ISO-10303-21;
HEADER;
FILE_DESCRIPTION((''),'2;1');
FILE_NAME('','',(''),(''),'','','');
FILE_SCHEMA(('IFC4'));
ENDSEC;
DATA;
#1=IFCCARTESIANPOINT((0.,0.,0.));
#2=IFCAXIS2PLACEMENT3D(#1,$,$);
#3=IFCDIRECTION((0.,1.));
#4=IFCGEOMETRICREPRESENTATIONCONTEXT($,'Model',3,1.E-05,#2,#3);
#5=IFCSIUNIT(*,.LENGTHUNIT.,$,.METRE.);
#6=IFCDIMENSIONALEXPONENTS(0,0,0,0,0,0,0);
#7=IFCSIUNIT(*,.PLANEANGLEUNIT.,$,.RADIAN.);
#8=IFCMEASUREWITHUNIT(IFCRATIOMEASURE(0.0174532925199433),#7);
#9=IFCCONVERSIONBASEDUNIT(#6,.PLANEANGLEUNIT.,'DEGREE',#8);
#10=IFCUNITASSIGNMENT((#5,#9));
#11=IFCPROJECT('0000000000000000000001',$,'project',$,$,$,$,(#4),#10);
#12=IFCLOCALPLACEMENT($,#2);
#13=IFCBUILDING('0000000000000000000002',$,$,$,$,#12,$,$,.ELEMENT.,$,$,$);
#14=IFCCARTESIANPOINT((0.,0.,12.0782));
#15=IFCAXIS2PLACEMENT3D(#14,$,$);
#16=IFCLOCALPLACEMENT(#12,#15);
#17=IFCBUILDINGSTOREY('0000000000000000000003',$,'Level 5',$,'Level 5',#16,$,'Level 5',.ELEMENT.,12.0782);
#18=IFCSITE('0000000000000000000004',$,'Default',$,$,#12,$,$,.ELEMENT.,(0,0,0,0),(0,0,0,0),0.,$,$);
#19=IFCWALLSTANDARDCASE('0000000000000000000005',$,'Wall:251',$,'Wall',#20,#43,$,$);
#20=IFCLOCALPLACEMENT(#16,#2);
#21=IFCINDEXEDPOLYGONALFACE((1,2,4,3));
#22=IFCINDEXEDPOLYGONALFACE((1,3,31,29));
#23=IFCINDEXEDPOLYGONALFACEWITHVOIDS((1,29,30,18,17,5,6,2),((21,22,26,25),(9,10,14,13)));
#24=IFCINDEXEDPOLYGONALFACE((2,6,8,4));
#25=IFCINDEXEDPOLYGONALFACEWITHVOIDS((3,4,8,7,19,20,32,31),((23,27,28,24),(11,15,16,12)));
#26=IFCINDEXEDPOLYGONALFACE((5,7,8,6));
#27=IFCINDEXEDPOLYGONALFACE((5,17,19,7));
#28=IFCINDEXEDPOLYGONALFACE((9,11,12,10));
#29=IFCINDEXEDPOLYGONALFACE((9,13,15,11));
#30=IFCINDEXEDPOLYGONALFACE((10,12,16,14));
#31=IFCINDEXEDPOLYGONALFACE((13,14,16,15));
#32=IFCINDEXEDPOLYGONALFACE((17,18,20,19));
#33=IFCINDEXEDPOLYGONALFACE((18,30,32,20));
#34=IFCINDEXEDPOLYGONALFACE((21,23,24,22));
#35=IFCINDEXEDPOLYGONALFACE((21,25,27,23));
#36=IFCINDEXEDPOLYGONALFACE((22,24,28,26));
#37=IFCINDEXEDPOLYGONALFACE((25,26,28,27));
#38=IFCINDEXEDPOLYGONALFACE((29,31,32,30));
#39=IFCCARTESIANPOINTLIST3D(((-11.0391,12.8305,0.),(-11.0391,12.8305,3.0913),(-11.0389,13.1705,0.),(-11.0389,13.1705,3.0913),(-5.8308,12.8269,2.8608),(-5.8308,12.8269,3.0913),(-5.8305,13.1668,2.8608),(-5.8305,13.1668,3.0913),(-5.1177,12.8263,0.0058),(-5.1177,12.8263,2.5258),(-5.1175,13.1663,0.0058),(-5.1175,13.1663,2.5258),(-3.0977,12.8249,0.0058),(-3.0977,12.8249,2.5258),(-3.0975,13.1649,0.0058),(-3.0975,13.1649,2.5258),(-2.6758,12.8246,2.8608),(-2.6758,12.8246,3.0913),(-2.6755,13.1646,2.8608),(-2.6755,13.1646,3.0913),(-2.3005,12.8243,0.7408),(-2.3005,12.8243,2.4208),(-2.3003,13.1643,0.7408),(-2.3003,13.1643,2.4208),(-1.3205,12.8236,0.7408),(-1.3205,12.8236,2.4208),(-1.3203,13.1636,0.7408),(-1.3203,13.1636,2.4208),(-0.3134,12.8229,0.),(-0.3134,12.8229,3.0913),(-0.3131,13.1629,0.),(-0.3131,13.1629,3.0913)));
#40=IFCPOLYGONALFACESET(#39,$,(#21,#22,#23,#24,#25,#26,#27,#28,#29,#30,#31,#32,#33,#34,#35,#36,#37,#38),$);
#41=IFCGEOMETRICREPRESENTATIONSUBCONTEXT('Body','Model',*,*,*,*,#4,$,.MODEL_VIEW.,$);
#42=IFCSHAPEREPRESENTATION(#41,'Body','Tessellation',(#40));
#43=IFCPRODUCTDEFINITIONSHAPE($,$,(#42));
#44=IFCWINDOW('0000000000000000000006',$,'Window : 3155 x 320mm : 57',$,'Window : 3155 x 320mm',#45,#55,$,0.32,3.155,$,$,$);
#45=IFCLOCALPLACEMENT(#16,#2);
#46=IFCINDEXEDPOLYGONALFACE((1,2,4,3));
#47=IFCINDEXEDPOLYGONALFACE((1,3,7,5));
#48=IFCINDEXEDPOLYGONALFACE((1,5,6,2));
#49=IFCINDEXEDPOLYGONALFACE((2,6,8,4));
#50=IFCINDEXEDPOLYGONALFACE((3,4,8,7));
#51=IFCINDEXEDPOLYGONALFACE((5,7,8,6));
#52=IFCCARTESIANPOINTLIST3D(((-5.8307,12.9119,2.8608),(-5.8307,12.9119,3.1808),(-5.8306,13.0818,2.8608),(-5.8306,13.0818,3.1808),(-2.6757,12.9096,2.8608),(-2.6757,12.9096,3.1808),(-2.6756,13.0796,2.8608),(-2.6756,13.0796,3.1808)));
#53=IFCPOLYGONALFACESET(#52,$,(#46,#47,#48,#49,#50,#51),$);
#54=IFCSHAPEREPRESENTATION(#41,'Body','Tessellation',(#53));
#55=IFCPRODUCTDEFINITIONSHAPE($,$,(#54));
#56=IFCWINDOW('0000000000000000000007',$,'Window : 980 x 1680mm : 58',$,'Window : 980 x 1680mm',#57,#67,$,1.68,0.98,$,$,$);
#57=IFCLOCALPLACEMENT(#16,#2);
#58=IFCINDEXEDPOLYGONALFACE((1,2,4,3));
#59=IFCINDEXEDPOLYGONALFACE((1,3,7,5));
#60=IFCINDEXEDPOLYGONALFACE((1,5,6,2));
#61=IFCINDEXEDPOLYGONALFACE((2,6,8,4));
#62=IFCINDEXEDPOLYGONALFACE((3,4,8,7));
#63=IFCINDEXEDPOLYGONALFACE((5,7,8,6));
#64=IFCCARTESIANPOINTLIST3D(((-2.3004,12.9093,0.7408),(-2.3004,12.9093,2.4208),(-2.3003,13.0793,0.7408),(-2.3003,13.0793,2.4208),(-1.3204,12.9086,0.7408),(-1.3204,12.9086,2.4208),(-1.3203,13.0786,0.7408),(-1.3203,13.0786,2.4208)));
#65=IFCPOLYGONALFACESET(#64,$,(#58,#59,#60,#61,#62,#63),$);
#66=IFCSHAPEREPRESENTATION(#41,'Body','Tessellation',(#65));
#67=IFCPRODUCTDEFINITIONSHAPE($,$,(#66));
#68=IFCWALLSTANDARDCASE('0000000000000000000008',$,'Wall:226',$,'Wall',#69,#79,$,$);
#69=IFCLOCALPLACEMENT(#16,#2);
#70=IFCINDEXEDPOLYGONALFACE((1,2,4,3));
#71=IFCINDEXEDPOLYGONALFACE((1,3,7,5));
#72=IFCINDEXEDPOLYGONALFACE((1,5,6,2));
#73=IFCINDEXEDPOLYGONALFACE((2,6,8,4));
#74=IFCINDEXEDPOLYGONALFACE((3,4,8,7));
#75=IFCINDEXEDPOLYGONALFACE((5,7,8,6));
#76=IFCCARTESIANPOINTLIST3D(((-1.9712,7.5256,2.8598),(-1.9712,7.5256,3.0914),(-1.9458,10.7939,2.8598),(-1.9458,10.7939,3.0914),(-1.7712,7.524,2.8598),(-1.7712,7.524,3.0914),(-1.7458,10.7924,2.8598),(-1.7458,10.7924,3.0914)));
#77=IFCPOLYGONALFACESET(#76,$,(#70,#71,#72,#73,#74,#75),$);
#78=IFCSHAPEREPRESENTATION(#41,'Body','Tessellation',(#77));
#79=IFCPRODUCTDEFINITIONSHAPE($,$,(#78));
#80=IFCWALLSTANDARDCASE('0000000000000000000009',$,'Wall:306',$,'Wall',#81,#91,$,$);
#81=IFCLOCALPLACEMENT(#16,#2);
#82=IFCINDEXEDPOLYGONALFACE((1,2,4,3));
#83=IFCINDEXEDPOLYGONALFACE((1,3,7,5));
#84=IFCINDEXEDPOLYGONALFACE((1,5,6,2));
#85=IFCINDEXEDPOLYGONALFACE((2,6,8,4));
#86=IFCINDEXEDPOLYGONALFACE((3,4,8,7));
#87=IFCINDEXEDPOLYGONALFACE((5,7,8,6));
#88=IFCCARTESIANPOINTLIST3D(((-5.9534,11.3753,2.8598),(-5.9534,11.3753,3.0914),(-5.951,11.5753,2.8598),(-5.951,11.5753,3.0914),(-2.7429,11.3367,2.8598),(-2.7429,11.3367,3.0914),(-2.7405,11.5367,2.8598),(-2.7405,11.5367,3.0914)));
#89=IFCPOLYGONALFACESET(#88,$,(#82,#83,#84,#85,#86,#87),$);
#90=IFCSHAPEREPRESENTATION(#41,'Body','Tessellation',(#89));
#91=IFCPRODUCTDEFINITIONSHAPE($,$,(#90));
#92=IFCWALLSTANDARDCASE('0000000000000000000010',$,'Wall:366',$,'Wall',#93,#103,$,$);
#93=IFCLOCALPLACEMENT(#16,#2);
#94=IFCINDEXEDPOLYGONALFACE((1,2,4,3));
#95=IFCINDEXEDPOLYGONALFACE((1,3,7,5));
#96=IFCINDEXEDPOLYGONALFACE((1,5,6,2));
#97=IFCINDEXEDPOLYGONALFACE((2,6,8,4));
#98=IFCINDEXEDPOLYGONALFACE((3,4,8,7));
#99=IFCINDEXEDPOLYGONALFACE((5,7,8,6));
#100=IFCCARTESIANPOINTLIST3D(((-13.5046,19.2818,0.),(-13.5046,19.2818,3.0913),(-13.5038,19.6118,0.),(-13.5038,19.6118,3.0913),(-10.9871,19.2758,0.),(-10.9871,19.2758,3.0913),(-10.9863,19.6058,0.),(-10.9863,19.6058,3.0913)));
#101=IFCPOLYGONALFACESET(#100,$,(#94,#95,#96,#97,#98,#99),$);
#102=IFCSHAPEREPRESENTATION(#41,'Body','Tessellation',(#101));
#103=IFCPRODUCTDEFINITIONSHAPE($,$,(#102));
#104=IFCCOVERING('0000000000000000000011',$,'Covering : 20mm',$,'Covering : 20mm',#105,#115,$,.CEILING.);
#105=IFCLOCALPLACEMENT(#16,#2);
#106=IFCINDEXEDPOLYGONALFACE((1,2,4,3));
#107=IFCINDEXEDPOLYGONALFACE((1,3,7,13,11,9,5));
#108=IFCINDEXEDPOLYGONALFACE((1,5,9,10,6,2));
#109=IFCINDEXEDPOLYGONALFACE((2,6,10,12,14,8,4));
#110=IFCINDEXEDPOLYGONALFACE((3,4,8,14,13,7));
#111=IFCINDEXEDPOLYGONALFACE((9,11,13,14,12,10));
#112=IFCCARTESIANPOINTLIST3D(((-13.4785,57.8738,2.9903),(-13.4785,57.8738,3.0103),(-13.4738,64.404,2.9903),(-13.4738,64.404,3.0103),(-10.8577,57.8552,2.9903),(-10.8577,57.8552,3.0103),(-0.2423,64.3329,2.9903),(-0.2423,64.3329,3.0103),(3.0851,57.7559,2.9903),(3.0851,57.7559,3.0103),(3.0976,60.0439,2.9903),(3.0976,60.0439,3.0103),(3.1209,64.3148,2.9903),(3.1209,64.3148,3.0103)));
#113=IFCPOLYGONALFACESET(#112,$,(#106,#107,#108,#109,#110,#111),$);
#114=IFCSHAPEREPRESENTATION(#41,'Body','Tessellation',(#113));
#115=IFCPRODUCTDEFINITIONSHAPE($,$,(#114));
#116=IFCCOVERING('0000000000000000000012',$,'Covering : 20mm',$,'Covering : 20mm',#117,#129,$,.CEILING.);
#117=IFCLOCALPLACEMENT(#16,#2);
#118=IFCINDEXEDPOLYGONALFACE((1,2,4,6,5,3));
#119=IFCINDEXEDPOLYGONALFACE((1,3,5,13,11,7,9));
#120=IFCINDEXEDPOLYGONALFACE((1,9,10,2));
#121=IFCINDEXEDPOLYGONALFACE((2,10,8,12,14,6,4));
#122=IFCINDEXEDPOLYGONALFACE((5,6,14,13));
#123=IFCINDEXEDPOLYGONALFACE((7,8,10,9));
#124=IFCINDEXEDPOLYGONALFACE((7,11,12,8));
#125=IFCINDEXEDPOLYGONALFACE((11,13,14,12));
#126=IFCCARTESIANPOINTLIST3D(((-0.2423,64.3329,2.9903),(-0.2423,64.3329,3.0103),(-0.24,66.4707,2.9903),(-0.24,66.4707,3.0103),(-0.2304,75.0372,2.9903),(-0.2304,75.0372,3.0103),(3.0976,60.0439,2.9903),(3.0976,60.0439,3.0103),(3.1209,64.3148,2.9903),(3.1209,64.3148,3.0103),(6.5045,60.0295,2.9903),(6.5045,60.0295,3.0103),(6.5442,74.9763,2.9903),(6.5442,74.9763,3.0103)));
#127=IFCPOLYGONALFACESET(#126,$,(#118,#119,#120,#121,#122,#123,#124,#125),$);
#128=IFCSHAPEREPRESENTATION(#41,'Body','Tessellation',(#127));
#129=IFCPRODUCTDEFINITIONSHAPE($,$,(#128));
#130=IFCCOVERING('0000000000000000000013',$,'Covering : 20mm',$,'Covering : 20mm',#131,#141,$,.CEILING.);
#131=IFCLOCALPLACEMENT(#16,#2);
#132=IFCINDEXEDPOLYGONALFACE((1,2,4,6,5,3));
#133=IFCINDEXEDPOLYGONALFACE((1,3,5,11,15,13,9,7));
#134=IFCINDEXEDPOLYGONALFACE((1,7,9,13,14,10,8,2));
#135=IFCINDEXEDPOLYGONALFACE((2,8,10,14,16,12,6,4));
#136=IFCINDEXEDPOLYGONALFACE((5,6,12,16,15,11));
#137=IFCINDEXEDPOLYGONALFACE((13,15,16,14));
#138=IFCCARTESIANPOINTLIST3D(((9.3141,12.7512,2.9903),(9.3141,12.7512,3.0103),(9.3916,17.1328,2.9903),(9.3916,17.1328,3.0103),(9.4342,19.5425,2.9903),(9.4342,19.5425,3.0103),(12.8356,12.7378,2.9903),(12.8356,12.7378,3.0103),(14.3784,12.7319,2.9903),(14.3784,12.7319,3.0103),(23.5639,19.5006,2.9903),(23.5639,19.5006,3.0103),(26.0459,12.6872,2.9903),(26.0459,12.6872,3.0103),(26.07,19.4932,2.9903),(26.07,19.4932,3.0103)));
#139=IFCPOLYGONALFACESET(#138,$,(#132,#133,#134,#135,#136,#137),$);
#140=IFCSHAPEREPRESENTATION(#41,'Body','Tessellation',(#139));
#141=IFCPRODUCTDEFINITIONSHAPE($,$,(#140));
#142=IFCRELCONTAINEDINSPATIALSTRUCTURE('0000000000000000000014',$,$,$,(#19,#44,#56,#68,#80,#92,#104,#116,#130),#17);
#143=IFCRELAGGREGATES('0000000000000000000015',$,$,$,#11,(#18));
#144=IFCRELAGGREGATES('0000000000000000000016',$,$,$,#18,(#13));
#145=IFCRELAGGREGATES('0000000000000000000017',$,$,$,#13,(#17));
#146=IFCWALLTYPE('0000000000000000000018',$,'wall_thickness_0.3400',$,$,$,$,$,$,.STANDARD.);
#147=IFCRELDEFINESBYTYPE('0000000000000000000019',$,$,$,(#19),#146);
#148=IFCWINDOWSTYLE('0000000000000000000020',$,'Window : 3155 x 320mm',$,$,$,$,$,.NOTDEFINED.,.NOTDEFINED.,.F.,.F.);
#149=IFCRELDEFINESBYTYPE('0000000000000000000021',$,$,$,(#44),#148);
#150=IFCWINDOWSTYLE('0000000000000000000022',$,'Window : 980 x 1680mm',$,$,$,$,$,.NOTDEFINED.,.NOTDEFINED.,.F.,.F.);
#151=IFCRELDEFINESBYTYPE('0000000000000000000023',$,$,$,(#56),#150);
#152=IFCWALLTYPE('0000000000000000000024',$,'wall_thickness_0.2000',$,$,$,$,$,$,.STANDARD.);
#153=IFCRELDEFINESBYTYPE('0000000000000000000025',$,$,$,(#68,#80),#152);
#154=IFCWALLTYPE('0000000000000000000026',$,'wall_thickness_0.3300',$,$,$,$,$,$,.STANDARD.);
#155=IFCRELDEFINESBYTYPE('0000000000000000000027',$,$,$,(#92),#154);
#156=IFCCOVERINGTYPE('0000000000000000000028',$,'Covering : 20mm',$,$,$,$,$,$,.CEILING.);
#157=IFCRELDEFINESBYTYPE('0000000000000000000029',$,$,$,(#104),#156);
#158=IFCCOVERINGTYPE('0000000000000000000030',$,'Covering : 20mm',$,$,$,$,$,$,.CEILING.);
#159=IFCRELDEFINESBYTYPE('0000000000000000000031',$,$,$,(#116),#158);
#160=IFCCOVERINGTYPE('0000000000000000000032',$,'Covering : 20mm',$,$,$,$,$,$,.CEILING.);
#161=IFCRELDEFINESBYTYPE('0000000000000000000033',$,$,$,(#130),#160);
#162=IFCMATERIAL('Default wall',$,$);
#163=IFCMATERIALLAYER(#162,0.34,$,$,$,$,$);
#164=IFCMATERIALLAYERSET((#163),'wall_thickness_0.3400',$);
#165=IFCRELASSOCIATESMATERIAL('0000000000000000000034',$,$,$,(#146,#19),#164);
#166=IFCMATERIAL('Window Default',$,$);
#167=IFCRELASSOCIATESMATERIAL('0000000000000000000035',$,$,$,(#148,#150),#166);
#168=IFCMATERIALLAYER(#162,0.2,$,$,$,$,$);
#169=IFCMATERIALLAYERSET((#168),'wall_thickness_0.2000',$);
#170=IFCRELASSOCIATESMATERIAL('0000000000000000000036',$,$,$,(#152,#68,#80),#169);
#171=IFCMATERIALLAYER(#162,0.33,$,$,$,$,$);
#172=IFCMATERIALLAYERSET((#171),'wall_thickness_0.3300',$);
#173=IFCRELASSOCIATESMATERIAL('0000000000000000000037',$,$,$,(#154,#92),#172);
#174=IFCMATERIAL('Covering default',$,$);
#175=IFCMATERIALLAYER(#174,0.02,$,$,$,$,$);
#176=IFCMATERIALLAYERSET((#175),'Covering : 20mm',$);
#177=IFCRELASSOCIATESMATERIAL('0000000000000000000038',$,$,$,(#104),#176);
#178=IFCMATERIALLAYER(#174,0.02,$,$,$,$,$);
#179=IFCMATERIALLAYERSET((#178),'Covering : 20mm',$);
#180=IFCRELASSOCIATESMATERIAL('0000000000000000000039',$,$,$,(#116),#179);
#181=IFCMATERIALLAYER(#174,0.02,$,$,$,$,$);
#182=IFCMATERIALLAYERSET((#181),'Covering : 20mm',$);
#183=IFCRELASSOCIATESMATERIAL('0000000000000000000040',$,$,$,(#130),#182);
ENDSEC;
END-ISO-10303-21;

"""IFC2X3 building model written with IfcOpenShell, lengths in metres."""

from ifc_helpers import new_model, entity, si_unit, converted_unit, direction, frame, frame_2d, origin, origin_with_axes, origin_2d_with_axis, place, context, subcontext, project, spatial, polyline, rectangle, outline, extrude, clip, halfspace, source, transform, mapped, material, layer, layer_set, layer_usage, type_object, type_shapes, element, fill, save


model = new_model("IFC2X3")

# Units and contexts
model_context = context("Model", 3, precision=1e-05, world=origin(), true_north=direction((0.0, 1.0)))
body_context = subcontext(model_context, "Body", "Model", "MODEL_VIEW")
ifc_project = project(units=[si_unit("LENGTHUNIT", "METRE"), converted_unit("PLANEANGLEUNIT", "DEGREE", entity("IfcRatioMeasure", 0.0174532925199433), si_unit("PLANEANGLEUNIT", "RADIAN"), dimensions=[0, 0, 0, 0, 0, 0, 0])], contexts=[model_context])

# Site, building, storey
placement_1 = place(None, origin())
site = spatial("IfcSite", under=ifc_project, at=placement_1, Name="Default", CompositionType="ELEMENT", RefLatitude=(0, 0, 0, 0), RefLongitude=(0, 0, 0, 0), RefElevation=0.0)
building = spatial("IfcBuilding", under=site, at=placement_1, CompositionType="ELEMENT")
storey_placement = place(placement_1, frame((0.0, 0.0, 12.0782)))
storey = spatial("IfcBuildingStorey", under=building, at=storey_placement, Name="Level 5", ObjectType="Level 5", LongName="Level 5", CompositionType="ELEMENT", Elevation=12.0782)

# Shared definitions
ifc_material_1 = material(Name="Default wall")
ifc_material_2 = material(Name="Window Default")

# Wall, openings, windows
ifc_layer_1 = layer(ifc_material_1, 0.34)
ifc_layer_set_1 = layer_set([ifc_layer_1], Name="wall_thickness_0.3400")
ifc_layer_usage_1 = layer_usage(ifc_layer_set_1, "AXIS2", "POSITIVE", -0.17)
wall_type_1 = type_object("IfcWallType", Name="wall_thickness_0.3400", PredefinedType="STANDARD", material=ifc_layer_set_1)
wall_1_placement = place(storey_placement, frame((-11.039, 13.0005, 0.0), z_axis=(0.0, 0.0, 1.0), x_axis=(1.0, -0.00071, 0.0)))
wall_1 = element("IfcWallStandardCase", 1, at=wall_1_placement, inside=storey, type_object=wall_type_1, material=ifc_layer_usage_1, Name="Wall:251", ObjectType="Wall", context=body_context, shape_type="Clipping", body=[
    clip(extrude(outline(polyline([(10.7257, -0.17), (10.7257, 0.17), (0.0, 0.17), (0.0, -0.17), (10.7257, -0.17)])), origin(), (0.0, 0.0, 1.0), 3.0913), halfspace(frame((-0.999, 6.5926, 8.9869), z_axis=(-0.004015, -0.38912, 0.921178), x_axis=(0.999958, -0.009108, 0.000511)), False)),
])
opening_1_placement = place(wall_1_placement, frame((5.9214, -0.17, 0.0058)))
element("IfcOpeningElement", 2, at=opening_1_placement, cuts=wall_1, ObjectType="Opening", context=body_context, shape_type="SweptSolid", body=[
    extrude(rectangle(XDim=2.02, YDim=2.52, at=frame_2d((1.26, 1.01), x_axis=(0.0, 1.0))), frame((0.0, 0.0, 0.0), z_axis=(0.0, 1.0, 0.0), x_axis=(0.0, 0.0, 1.0)), (0.0, 0.0, 1.0), 0.34),
])
opening_2_placement = place(wall_1_placement, frame((5.2083, -0.17, 2.8608)))
opening_2 = element("IfcOpeningElement", 3, at=opening_2_placement, cuts=wall_1, ObjectType="Opening", context=body_context, shape_type="SweptSolid", body=[
    extrude(rectangle(XDim=3.155, YDim=0.32, at=frame_2d((0.16, 1.5775), x_axis=(0.0, 1.0))), frame((0.0, 0.0, 0.0), z_axis=(0.0, 1.0, 0.0), x_axis=(0.0, 0.0, 1.0)), (0.0, 0.0, 1.0), 0.34),
])
opening_3_placement = place(wall_1_placement, frame((8.7386, -0.17, 0.7408)))
opening_3 = element("IfcOpeningElement", 4, at=opening_3_placement, cuts=wall_1, ObjectType="Opening", context=body_context, shape_type="SweptSolid", body=[
    extrude(rectangle(XDim=0.98, YDim=1.68, at=frame_2d((0.84, 0.49), x_axis=(0.0, 1.0))), frame((0.0, 0.0, 0.0), z_axis=(0.0, 1.0, 0.0), x_axis=(0.0, 0.0, 1.0)), (0.0, 0.0, 1.0), 0.34),
])
window_style_1 = type_object("IfcWindowStyle", Name="Window : 3155 x 320mm", ConstructionType="NOTDEFINED", OperationType="NOTDEFINED", ParameterTakesPrecedence=False, Sizeable=False, material=ifc_material_2)
shared_shape_1 = source(origin(), body_context, "Body", "SweptSolid", [
    extrude(rectangle(XDim=0.17, YDim=3.155, at=origin_2d_with_axis()), frame((1.5775, 0.17, 0.0), z_axis=(0.0, 0.0, 1.0), x_axis=(0.0, 1.0, 0.0)), (0.0, 0.0, 1.0), 0.32),
])
type_shapes(window_style_1, [shared_shape_1])
window_1_placement = place(opening_2_placement, origin())
window_1 = element("IfcWindow", 5, at=window_1_placement, inside=storey, type_object=window_style_1, Name="Window : 3155 x 320mm : 57", ObjectType="Window : 3155 x 320mm", OverallHeight=0.32, OverallWidth=3.155, context=body_context, shape_type="MappedRepresentation", body=[
    mapped(shared_shape_1, transform((0.0, 0.0, 0.0), scale=1.0)),
])
fill(opening_2, window_1)
window_style_2 = type_object("IfcWindowStyle", Name="Window : 980 x 1680mm", ConstructionType="NOTDEFINED", OperationType="NOTDEFINED", ParameterTakesPrecedence=False, Sizeable=False, material=ifc_material_2)
shared_shape_2 = source(origin(), body_context, "Body", "SweptSolid", [
    extrude(rectangle(XDim=0.17, YDim=0.98, at=origin_2d_with_axis()), frame((0.49, 0.17, 0.0), z_axis=(0.0, 0.0, 1.0), x_axis=(0.0, 1.0, 0.0)), (0.0, 0.0, 1.0), 1.68),
])
type_shapes(window_style_2, [shared_shape_2])
window_2_placement = place(opening_3_placement, origin())
window_2 = element("IfcWindow", 6, at=window_2_placement, inside=storey, type_object=window_style_2, Name="Window : 980 x 1680mm : 58", ObjectType="Window : 980 x 1680mm", OverallHeight=1.68, OverallWidth=0.98, context=body_context, shape_type="MappedRepresentation", body=[
    mapped(shared_shape_2, transform((0.0, 0.0, 0.0), scale=1.0)),
])
fill(opening_3, window_2)

# Walls
ifc_layer_2 = layer(ifc_material_1, 0.2)
ifc_layer_set_2 = layer_set([ifc_layer_2], Name="wall_thickness_0.2000")
ifc_layer_usage_2 = layer_usage(ifc_layer_set_2, "AXIS2", "POSITIVE", -0.1)
wall_type_2 = type_object("IfcWallType", Name="wall_thickness_0.2000", PredefinedType="STANDARD", material=ifc_layer_set_2)
placement_2 = place(placement_1, frame((0.0, 0.0, 14.938)))
wall_2_placement = place(placement_2, frame((-1.8458, 10.7932, 0.0), z_axis=(0.0, 0.0, 1.0), x_axis=(-0.007747, -0.99997, 0.0)))
element("IfcWallStandardCase", 7, at=wall_2_placement, inside=storey, type_object=wall_type_2, material=ifc_layer_usage_2, Name="Wall:226", ObjectType="Wall", context=body_context, shape_type="SweptSolid", body=[
    extrude(outline(polyline([(3.2685, -0.1), (3.2685, 0.1), (0.0, 0.1), (0.0, -0.1), (3.2685, -0.1)])), origin(), (0.0, 0.0, 1.0), 0.2316),
])
placement_3 = place(placement_1, frame((0.0, 0.0, 14.938)))
wall_3_placement = place(placement_3, frame((-5.9522, 11.4753, 0.0), z_axis=(0.0, 0.0, 1.0), x_axis=(0.999928, -0.012018, 0.0)))
element("IfcWallStandardCase", 8, at=wall_3_placement, inside=storey, type_object=wall_type_2, material=ifc_layer_usage_2, Name="Wall:306", ObjectType="Wall", context=body_context, shape_type="SweptSolid", body=[
    extrude(outline(polyline([(3.2108, -0.1), (3.2108, 0.1), (0.0, 0.1), (0.0, -0.1), (3.2108, -0.1)])), origin(), (0.0, 0.0, 1.0), 0.2316),
])
ifc_layer_3 = layer(ifc_material_1, 0.33)
ifc_layer_set_3 = layer_set([ifc_layer_3], Name="wall_thickness_0.3300")
ifc_layer_usage_3 = layer_usage(ifc_layer_set_3, "AXIS2", "POSITIVE", -0.165)
wall_type_3 = type_object("IfcWallType", Name="wall_thickness_0.3300", PredefinedType="STANDARD", material=ifc_layer_set_3)
wall_4_placement = place(storey_placement, frame((-13.5042, 19.4468, 0.0), z_axis=(0.0, 0.0, 1.0), x_axis=(0.999997, -0.002393, 0.0)))
element("IfcWallStandardCase", 9, at=wall_4_placement, inside=storey, type_object=wall_type_3, material=ifc_layer_usage_3, Name="Wall:366", ObjectType="Wall", context=body_context, shape_type="SweptSolid", body=[
    extrude(outline(polyline([(2.5175, -0.165), (2.5175, 0.165), (0.0, 0.165), (0.0, -0.165), (2.5175, -0.165)])), origin(), (0.0, 0.0, 1.0), 3.0913),
])

# Coverings
ifc_material_3 = material(Name="Covering default")
ifc_layer_4 = layer(ifc_material_3, 0.02)
ifc_layer_set_4 = layer_set([ifc_layer_4], Name="Covering : 20mm")
ifc_layer_usage_4 = layer_usage(ifc_layer_set_4, "AXIS3", "POSITIVE", 0.0)
covering_type_1 = type_object("IfcCoveringType", Name="Covering : 20mm", PredefinedType="CEILING")
covering_1_placement = place(placement_1, frame((0.0, 0.0, 15.0685)))
element("IfcCovering", 10, at=covering_1_placement, inside=storey, type_object=covering_type_1, material=ifc_layer_usage_4, Name="Covering : 20mm", ObjectType="Covering : 20mm", PredefinedType="CEILING", context=body_context, shape_type="SweptSolid", body=[
    extrude(outline(polyline([(3.1209, 64.3148), (-0.2423, 64.3329), (-13.4738, 64.404), (-13.4785, 57.8738), (-10.8577, 57.8552), (3.0851, 57.7559), (3.0976, 60.0439), (3.1209, 64.3148)])), origin_with_axes(), (0.0, 0.0, 1.0), 0.02),
])
ifc_layer_5 = layer(ifc_material_3, 0.02)
ifc_layer_set_5 = layer_set([ifc_layer_5], Name="Covering : 20mm")
ifc_layer_usage_5 = layer_usage(ifc_layer_set_5, "AXIS3", "POSITIVE", 0.0)
covering_type_2 = type_object("IfcCoveringType", Name="Covering : 20mm", PredefinedType="CEILING")
covering_2_placement = place(placement_1, frame((0.0, 0.0, 15.0685)))
element("IfcCovering", 11, at=covering_2_placement, inside=storey, type_object=covering_type_2, material=ifc_layer_usage_5, Name="Covering : 20mm", ObjectType="Covering : 20mm", PredefinedType="CEILING", context=body_context, shape_type="SweptSolid", body=[
    extrude(outline(polyline([(6.5442, 74.9763), (6.5045, 60.0295), (3.0976, 60.0439), (3.1209, 64.3148), (-0.2423, 64.3329), (-0.24, 66.4707), (-0.2304, 75.0372), (6.5442, 74.9763)])), origin_with_axes(), (0.0, 0.0, 1.0), 0.02),
])
ifc_layer_6 = layer(ifc_material_3, 0.02)
ifc_layer_set_6 = layer_set([ifc_layer_6], Name="Covering : 20mm")
ifc_layer_usage_6 = layer_usage(ifc_layer_set_6, "AXIS3", "POSITIVE", 0.0)
covering_type_3 = type_object("IfcCoveringType", Name="Covering : 20mm", PredefinedType="CEILING")
covering_3_placement = place(placement_1, frame((0.0, 0.0, 15.0685)))
element("IfcCovering", 12, at=covering_3_placement, inside=storey, type_object=covering_type_3, material=ifc_layer_usage_6, Name="Covering : 20mm", ObjectType="Covering : 20mm", PredefinedType="CEILING", context=body_context, shape_type="SweptSolid", body=[
    extrude(outline(polyline([(9.3916, 17.1328), (9.3141, 12.7512), (12.8356, 12.7378), (14.3784, 12.7319), (26.0459, 12.6872), (26.07, 19.4932), (23.5639, 19.5006), (9.4342, 19.5425), (9.3916, 17.1328)])), origin_with_axes(), (0.0, 0.0, 1.0), 0.02),
])

save(model, "model.ifc")
